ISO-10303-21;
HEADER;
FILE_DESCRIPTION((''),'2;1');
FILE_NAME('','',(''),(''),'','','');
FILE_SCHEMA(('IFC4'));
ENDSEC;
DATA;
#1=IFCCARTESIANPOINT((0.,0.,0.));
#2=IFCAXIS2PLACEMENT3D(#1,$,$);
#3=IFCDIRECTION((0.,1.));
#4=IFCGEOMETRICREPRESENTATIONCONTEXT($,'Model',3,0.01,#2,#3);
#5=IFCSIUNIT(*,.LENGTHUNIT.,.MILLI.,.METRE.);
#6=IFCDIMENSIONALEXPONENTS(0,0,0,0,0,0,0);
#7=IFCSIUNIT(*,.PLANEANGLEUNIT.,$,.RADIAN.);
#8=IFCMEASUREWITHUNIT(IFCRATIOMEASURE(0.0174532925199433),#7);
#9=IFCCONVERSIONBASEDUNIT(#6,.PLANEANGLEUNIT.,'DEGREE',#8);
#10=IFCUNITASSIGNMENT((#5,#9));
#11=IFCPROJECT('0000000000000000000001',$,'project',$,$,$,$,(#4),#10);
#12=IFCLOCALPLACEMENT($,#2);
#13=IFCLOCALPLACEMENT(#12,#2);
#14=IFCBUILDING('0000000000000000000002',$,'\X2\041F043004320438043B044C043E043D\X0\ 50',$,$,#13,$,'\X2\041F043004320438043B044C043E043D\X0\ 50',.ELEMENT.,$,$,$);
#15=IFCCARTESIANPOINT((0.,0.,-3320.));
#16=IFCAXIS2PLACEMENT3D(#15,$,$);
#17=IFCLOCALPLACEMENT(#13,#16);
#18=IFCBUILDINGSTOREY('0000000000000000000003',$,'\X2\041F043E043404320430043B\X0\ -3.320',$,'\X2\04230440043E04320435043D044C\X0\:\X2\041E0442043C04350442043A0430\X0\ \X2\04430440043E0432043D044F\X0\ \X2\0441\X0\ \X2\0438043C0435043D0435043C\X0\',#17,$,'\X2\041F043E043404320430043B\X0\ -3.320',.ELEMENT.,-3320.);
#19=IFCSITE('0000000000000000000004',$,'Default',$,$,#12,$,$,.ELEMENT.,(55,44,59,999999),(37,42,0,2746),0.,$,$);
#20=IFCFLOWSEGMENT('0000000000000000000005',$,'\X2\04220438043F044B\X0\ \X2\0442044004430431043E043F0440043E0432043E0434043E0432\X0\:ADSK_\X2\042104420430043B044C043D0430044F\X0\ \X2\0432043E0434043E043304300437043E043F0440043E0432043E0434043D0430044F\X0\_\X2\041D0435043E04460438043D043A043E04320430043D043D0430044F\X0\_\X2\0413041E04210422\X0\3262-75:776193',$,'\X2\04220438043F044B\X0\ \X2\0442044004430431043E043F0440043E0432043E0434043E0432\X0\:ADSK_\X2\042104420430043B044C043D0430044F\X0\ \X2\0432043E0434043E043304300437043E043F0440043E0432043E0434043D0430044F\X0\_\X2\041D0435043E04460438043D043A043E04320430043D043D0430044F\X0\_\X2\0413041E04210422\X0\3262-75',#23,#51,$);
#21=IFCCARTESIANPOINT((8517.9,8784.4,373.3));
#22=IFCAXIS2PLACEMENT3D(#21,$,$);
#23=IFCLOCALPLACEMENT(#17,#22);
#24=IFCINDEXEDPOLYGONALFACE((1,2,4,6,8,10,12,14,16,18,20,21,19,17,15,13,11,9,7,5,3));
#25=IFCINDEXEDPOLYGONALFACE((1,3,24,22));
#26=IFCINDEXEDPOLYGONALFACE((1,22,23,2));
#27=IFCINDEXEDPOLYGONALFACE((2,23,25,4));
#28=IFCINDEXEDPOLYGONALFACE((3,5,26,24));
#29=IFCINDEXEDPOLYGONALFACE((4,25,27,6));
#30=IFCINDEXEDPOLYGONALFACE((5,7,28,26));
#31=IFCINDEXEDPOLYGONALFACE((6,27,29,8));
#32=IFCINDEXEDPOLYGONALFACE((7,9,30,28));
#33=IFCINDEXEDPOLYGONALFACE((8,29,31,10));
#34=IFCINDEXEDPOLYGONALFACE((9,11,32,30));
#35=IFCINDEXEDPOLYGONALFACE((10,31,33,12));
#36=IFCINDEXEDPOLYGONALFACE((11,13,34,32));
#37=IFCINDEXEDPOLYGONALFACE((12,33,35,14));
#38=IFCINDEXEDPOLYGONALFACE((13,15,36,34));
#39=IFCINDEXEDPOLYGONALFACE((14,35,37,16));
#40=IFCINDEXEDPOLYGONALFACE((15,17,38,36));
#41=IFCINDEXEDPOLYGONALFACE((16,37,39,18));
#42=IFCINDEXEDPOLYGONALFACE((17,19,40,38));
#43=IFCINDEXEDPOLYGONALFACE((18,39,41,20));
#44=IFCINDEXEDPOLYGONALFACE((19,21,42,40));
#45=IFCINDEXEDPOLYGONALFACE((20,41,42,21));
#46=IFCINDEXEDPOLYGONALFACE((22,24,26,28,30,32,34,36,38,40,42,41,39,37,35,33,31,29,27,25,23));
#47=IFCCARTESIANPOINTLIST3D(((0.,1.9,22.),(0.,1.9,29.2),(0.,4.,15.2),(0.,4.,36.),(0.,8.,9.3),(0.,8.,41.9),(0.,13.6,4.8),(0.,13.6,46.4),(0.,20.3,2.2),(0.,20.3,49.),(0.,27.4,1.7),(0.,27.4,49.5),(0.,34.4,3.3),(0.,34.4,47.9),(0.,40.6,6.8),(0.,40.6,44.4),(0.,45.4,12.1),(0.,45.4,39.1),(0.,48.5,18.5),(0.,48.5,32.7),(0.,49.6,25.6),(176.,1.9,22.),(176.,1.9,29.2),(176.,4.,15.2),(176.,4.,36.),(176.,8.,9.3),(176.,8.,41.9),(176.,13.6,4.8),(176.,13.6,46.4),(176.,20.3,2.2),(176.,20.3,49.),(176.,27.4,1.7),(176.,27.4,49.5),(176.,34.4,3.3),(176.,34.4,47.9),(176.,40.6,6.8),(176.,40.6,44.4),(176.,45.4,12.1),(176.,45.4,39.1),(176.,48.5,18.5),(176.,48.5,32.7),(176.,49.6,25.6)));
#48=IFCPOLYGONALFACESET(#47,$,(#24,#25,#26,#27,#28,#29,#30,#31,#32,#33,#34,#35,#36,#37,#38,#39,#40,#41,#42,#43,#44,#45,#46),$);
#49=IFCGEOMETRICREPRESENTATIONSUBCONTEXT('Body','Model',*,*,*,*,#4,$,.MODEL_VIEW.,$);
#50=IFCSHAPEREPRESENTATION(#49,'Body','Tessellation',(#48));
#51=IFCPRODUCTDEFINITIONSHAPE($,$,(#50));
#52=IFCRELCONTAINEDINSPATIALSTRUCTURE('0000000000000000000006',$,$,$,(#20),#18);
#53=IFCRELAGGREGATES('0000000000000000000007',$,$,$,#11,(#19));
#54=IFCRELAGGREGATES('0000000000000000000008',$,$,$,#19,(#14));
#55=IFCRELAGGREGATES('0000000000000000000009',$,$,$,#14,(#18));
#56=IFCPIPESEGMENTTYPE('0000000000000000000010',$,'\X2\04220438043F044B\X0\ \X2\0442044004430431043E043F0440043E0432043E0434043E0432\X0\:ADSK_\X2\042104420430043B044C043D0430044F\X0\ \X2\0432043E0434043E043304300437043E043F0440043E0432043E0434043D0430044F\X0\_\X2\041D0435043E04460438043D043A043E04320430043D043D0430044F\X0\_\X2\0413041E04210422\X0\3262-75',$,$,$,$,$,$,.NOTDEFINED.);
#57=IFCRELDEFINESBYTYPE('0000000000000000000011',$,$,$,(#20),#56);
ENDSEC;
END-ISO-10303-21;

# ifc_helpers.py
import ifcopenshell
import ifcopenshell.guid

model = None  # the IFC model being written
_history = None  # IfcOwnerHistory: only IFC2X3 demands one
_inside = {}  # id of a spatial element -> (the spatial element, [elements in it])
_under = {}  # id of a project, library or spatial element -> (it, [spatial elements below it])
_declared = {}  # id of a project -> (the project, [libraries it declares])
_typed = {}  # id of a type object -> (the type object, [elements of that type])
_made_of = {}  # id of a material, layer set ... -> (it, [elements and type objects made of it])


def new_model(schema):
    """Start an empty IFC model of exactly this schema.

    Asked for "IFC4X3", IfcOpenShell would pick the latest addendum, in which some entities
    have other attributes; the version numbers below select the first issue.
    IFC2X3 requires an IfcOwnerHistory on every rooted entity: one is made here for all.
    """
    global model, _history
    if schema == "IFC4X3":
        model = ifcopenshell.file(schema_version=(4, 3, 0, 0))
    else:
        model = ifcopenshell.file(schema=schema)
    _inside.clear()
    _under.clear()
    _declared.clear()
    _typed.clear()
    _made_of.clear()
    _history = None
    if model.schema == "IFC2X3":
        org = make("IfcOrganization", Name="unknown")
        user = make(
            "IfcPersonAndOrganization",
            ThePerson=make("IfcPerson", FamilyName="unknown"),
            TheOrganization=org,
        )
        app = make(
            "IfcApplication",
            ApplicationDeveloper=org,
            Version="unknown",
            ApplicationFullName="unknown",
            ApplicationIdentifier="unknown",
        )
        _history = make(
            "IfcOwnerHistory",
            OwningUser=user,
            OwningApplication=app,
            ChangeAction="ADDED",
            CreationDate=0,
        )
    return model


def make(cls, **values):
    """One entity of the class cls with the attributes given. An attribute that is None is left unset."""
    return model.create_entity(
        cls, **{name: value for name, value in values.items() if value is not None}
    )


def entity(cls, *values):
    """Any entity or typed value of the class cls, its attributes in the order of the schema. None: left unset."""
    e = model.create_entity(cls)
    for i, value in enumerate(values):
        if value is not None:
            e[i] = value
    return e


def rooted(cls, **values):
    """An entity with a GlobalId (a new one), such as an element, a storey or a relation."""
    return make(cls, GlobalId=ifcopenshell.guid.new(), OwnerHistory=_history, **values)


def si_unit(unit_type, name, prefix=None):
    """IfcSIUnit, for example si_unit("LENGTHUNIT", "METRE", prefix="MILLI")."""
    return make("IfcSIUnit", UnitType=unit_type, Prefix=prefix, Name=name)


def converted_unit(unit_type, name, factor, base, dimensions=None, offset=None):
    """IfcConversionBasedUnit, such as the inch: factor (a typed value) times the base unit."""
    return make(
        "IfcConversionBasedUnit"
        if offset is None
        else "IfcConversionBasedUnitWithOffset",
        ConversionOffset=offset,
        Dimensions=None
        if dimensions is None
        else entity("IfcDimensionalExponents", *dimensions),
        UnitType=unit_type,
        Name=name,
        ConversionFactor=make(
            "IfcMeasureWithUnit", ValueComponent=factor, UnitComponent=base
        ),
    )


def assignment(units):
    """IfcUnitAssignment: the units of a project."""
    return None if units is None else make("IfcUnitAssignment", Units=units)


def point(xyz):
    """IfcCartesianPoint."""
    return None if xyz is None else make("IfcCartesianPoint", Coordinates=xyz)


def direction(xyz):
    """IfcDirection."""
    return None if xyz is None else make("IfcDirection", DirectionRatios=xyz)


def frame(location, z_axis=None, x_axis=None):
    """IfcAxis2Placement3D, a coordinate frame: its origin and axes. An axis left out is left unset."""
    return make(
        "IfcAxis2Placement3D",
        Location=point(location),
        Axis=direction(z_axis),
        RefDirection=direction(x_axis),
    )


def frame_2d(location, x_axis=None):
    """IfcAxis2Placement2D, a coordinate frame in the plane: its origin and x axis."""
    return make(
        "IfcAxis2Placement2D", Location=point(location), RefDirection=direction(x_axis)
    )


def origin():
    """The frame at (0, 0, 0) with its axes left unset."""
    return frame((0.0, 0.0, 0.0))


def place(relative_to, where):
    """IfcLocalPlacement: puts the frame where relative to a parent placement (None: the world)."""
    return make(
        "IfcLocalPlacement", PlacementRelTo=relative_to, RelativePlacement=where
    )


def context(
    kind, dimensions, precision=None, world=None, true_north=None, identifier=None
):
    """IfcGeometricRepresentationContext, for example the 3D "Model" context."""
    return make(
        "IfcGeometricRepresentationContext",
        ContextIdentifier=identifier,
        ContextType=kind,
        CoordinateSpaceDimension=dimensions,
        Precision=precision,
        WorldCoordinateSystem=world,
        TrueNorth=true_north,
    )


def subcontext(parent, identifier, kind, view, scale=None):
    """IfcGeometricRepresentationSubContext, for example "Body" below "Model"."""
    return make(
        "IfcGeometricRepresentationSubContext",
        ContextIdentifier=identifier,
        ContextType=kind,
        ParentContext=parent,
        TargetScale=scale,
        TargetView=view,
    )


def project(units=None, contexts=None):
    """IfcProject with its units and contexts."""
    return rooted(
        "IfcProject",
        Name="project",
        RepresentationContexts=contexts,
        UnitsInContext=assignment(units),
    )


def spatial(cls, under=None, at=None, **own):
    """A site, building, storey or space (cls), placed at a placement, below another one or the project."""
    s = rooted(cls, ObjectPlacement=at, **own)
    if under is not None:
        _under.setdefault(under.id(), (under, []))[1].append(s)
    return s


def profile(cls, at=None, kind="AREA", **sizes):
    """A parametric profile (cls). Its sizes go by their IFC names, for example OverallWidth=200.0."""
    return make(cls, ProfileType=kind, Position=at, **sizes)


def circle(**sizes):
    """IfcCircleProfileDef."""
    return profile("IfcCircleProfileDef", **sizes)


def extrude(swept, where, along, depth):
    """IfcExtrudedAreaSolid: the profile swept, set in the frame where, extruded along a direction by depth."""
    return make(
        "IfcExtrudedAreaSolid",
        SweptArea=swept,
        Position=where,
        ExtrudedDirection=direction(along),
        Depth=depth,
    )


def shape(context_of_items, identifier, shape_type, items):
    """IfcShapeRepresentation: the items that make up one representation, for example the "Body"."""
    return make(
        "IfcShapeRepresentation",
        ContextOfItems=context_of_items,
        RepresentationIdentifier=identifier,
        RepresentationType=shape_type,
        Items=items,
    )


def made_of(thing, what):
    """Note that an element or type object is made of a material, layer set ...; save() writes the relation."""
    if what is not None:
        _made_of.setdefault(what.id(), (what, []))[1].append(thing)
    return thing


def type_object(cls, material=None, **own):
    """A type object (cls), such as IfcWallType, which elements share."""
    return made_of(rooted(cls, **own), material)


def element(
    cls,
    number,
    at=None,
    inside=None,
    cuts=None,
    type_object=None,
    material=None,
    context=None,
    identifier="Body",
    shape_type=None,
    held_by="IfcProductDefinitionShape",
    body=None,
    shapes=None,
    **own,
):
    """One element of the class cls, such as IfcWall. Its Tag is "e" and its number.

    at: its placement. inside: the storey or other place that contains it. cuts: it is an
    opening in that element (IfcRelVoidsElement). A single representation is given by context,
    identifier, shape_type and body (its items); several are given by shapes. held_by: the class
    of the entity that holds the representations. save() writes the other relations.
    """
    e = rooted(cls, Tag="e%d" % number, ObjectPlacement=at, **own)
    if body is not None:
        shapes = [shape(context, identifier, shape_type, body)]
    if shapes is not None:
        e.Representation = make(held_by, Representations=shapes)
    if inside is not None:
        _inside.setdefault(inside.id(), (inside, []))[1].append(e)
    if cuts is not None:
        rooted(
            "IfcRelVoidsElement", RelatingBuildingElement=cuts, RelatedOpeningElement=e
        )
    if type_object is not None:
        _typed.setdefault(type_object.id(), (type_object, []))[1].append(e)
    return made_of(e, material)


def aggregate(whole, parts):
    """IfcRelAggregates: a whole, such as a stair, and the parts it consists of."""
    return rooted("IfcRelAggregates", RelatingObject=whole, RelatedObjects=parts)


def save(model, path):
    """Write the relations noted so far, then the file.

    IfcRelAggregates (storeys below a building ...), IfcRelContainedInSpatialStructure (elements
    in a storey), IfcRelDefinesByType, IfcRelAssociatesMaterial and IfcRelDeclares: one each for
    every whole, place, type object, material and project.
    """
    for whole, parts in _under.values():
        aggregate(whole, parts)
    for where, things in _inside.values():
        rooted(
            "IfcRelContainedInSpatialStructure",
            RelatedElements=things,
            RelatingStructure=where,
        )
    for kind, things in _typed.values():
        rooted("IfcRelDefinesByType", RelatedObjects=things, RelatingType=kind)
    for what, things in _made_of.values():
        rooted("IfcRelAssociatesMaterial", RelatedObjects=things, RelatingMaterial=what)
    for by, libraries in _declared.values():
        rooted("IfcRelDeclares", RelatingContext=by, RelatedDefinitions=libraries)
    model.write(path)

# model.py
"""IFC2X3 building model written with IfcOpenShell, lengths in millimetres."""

from ifc_helpers import new_model, entity, si_unit, converted_unit, direction, frame, frame_2d, origin, place, context, subcontext, project, spatial, circle, extrude, type_object, element, save


model = new_model("IFC2X3")

# Units and contexts
model_context = context("Model", 3, precision=0.01, world=origin(), true_north=direction((0.0, 1.0)))
body_context = subcontext(model_context, "Body", "Model", "MODEL_VIEW")
ifc_project = project(units=[si_unit("LENGTHUNIT", "METRE", prefix="MILLI"), converted_unit("PLANEANGLEUNIT", "DEGREE", entity("IfcRatioMeasure", 0.0174532925199433), si_unit("PLANEANGLEUNIT", "RADIAN"), dimensions=[0, 0, 0, 0, 0, 0, 0])], contexts=[model_context])

# Site, building, storey
site_placement = place(None, origin())
site = spatial("IfcSite", under=ifc_project, at=site_placement, Name="Default", CompositionType="ELEMENT", RefLatitude=(55, 44, 59, 999999), RefLongitude=(37, 42, 0, 2746), RefElevation=0.0)
building_placement = place(site_placement, origin())
building = spatial("IfcBuilding", under=site, at=building_placement, Name="Павильон 50", LongName="Павильон 50", CompositionType="ELEMENT")
storey_placement = place(building_placement, frame((0.0, 0.0, -3320.0)))
storey = spatial("IfcBuildingStorey", under=building, at=storey_placement, Name="Подвал -3.320", ObjectType="Уровень:Отметка уровня с именем", LongName="Подвал -3.320", CompositionType="ELEMENT", Elevation=-3320.0)

# Flow segment
pipe_segment_type = type_object("IfcPipeSegmentType", Name="Типы трубопроводов:ADSK_Стальная водогазопроводная_Неоцинкованная_ГОСТ3262-75", PredefinedType="NOTDEFINED")
flow_segment_1_placement = place(storey_placement, frame((8517.9, 8784.4, 373.3)))
element("IfcFlowSegment", 1, at=flow_segment_1_placement, inside=storey, type_object=pipe_segment_type, Name="Типы трубопроводов:ADSK_Стальная водогазопроводная_Неоцинкованная_ГОСТ3262-75:776193", ObjectType="Типы трубопроводов:ADSK_Стальная водогазопроводная_Неоцинкованная_ГОСТ3262-75", context=body_context, shape_type="SweptSolid", body=[
    extrude(circle(Radius=24.0, at=frame_2d((0.0, 0.0), x_axis=(1.0, 0.0))), frame((0.0, 25.6, 25.6), z_axis=(1.0, 0.0, 0.0), x_axis=(0.0, 1.0, 0.0)), (0.0, 0.0, 1.0), 176.0),
])

save(model, "model.ifc")
